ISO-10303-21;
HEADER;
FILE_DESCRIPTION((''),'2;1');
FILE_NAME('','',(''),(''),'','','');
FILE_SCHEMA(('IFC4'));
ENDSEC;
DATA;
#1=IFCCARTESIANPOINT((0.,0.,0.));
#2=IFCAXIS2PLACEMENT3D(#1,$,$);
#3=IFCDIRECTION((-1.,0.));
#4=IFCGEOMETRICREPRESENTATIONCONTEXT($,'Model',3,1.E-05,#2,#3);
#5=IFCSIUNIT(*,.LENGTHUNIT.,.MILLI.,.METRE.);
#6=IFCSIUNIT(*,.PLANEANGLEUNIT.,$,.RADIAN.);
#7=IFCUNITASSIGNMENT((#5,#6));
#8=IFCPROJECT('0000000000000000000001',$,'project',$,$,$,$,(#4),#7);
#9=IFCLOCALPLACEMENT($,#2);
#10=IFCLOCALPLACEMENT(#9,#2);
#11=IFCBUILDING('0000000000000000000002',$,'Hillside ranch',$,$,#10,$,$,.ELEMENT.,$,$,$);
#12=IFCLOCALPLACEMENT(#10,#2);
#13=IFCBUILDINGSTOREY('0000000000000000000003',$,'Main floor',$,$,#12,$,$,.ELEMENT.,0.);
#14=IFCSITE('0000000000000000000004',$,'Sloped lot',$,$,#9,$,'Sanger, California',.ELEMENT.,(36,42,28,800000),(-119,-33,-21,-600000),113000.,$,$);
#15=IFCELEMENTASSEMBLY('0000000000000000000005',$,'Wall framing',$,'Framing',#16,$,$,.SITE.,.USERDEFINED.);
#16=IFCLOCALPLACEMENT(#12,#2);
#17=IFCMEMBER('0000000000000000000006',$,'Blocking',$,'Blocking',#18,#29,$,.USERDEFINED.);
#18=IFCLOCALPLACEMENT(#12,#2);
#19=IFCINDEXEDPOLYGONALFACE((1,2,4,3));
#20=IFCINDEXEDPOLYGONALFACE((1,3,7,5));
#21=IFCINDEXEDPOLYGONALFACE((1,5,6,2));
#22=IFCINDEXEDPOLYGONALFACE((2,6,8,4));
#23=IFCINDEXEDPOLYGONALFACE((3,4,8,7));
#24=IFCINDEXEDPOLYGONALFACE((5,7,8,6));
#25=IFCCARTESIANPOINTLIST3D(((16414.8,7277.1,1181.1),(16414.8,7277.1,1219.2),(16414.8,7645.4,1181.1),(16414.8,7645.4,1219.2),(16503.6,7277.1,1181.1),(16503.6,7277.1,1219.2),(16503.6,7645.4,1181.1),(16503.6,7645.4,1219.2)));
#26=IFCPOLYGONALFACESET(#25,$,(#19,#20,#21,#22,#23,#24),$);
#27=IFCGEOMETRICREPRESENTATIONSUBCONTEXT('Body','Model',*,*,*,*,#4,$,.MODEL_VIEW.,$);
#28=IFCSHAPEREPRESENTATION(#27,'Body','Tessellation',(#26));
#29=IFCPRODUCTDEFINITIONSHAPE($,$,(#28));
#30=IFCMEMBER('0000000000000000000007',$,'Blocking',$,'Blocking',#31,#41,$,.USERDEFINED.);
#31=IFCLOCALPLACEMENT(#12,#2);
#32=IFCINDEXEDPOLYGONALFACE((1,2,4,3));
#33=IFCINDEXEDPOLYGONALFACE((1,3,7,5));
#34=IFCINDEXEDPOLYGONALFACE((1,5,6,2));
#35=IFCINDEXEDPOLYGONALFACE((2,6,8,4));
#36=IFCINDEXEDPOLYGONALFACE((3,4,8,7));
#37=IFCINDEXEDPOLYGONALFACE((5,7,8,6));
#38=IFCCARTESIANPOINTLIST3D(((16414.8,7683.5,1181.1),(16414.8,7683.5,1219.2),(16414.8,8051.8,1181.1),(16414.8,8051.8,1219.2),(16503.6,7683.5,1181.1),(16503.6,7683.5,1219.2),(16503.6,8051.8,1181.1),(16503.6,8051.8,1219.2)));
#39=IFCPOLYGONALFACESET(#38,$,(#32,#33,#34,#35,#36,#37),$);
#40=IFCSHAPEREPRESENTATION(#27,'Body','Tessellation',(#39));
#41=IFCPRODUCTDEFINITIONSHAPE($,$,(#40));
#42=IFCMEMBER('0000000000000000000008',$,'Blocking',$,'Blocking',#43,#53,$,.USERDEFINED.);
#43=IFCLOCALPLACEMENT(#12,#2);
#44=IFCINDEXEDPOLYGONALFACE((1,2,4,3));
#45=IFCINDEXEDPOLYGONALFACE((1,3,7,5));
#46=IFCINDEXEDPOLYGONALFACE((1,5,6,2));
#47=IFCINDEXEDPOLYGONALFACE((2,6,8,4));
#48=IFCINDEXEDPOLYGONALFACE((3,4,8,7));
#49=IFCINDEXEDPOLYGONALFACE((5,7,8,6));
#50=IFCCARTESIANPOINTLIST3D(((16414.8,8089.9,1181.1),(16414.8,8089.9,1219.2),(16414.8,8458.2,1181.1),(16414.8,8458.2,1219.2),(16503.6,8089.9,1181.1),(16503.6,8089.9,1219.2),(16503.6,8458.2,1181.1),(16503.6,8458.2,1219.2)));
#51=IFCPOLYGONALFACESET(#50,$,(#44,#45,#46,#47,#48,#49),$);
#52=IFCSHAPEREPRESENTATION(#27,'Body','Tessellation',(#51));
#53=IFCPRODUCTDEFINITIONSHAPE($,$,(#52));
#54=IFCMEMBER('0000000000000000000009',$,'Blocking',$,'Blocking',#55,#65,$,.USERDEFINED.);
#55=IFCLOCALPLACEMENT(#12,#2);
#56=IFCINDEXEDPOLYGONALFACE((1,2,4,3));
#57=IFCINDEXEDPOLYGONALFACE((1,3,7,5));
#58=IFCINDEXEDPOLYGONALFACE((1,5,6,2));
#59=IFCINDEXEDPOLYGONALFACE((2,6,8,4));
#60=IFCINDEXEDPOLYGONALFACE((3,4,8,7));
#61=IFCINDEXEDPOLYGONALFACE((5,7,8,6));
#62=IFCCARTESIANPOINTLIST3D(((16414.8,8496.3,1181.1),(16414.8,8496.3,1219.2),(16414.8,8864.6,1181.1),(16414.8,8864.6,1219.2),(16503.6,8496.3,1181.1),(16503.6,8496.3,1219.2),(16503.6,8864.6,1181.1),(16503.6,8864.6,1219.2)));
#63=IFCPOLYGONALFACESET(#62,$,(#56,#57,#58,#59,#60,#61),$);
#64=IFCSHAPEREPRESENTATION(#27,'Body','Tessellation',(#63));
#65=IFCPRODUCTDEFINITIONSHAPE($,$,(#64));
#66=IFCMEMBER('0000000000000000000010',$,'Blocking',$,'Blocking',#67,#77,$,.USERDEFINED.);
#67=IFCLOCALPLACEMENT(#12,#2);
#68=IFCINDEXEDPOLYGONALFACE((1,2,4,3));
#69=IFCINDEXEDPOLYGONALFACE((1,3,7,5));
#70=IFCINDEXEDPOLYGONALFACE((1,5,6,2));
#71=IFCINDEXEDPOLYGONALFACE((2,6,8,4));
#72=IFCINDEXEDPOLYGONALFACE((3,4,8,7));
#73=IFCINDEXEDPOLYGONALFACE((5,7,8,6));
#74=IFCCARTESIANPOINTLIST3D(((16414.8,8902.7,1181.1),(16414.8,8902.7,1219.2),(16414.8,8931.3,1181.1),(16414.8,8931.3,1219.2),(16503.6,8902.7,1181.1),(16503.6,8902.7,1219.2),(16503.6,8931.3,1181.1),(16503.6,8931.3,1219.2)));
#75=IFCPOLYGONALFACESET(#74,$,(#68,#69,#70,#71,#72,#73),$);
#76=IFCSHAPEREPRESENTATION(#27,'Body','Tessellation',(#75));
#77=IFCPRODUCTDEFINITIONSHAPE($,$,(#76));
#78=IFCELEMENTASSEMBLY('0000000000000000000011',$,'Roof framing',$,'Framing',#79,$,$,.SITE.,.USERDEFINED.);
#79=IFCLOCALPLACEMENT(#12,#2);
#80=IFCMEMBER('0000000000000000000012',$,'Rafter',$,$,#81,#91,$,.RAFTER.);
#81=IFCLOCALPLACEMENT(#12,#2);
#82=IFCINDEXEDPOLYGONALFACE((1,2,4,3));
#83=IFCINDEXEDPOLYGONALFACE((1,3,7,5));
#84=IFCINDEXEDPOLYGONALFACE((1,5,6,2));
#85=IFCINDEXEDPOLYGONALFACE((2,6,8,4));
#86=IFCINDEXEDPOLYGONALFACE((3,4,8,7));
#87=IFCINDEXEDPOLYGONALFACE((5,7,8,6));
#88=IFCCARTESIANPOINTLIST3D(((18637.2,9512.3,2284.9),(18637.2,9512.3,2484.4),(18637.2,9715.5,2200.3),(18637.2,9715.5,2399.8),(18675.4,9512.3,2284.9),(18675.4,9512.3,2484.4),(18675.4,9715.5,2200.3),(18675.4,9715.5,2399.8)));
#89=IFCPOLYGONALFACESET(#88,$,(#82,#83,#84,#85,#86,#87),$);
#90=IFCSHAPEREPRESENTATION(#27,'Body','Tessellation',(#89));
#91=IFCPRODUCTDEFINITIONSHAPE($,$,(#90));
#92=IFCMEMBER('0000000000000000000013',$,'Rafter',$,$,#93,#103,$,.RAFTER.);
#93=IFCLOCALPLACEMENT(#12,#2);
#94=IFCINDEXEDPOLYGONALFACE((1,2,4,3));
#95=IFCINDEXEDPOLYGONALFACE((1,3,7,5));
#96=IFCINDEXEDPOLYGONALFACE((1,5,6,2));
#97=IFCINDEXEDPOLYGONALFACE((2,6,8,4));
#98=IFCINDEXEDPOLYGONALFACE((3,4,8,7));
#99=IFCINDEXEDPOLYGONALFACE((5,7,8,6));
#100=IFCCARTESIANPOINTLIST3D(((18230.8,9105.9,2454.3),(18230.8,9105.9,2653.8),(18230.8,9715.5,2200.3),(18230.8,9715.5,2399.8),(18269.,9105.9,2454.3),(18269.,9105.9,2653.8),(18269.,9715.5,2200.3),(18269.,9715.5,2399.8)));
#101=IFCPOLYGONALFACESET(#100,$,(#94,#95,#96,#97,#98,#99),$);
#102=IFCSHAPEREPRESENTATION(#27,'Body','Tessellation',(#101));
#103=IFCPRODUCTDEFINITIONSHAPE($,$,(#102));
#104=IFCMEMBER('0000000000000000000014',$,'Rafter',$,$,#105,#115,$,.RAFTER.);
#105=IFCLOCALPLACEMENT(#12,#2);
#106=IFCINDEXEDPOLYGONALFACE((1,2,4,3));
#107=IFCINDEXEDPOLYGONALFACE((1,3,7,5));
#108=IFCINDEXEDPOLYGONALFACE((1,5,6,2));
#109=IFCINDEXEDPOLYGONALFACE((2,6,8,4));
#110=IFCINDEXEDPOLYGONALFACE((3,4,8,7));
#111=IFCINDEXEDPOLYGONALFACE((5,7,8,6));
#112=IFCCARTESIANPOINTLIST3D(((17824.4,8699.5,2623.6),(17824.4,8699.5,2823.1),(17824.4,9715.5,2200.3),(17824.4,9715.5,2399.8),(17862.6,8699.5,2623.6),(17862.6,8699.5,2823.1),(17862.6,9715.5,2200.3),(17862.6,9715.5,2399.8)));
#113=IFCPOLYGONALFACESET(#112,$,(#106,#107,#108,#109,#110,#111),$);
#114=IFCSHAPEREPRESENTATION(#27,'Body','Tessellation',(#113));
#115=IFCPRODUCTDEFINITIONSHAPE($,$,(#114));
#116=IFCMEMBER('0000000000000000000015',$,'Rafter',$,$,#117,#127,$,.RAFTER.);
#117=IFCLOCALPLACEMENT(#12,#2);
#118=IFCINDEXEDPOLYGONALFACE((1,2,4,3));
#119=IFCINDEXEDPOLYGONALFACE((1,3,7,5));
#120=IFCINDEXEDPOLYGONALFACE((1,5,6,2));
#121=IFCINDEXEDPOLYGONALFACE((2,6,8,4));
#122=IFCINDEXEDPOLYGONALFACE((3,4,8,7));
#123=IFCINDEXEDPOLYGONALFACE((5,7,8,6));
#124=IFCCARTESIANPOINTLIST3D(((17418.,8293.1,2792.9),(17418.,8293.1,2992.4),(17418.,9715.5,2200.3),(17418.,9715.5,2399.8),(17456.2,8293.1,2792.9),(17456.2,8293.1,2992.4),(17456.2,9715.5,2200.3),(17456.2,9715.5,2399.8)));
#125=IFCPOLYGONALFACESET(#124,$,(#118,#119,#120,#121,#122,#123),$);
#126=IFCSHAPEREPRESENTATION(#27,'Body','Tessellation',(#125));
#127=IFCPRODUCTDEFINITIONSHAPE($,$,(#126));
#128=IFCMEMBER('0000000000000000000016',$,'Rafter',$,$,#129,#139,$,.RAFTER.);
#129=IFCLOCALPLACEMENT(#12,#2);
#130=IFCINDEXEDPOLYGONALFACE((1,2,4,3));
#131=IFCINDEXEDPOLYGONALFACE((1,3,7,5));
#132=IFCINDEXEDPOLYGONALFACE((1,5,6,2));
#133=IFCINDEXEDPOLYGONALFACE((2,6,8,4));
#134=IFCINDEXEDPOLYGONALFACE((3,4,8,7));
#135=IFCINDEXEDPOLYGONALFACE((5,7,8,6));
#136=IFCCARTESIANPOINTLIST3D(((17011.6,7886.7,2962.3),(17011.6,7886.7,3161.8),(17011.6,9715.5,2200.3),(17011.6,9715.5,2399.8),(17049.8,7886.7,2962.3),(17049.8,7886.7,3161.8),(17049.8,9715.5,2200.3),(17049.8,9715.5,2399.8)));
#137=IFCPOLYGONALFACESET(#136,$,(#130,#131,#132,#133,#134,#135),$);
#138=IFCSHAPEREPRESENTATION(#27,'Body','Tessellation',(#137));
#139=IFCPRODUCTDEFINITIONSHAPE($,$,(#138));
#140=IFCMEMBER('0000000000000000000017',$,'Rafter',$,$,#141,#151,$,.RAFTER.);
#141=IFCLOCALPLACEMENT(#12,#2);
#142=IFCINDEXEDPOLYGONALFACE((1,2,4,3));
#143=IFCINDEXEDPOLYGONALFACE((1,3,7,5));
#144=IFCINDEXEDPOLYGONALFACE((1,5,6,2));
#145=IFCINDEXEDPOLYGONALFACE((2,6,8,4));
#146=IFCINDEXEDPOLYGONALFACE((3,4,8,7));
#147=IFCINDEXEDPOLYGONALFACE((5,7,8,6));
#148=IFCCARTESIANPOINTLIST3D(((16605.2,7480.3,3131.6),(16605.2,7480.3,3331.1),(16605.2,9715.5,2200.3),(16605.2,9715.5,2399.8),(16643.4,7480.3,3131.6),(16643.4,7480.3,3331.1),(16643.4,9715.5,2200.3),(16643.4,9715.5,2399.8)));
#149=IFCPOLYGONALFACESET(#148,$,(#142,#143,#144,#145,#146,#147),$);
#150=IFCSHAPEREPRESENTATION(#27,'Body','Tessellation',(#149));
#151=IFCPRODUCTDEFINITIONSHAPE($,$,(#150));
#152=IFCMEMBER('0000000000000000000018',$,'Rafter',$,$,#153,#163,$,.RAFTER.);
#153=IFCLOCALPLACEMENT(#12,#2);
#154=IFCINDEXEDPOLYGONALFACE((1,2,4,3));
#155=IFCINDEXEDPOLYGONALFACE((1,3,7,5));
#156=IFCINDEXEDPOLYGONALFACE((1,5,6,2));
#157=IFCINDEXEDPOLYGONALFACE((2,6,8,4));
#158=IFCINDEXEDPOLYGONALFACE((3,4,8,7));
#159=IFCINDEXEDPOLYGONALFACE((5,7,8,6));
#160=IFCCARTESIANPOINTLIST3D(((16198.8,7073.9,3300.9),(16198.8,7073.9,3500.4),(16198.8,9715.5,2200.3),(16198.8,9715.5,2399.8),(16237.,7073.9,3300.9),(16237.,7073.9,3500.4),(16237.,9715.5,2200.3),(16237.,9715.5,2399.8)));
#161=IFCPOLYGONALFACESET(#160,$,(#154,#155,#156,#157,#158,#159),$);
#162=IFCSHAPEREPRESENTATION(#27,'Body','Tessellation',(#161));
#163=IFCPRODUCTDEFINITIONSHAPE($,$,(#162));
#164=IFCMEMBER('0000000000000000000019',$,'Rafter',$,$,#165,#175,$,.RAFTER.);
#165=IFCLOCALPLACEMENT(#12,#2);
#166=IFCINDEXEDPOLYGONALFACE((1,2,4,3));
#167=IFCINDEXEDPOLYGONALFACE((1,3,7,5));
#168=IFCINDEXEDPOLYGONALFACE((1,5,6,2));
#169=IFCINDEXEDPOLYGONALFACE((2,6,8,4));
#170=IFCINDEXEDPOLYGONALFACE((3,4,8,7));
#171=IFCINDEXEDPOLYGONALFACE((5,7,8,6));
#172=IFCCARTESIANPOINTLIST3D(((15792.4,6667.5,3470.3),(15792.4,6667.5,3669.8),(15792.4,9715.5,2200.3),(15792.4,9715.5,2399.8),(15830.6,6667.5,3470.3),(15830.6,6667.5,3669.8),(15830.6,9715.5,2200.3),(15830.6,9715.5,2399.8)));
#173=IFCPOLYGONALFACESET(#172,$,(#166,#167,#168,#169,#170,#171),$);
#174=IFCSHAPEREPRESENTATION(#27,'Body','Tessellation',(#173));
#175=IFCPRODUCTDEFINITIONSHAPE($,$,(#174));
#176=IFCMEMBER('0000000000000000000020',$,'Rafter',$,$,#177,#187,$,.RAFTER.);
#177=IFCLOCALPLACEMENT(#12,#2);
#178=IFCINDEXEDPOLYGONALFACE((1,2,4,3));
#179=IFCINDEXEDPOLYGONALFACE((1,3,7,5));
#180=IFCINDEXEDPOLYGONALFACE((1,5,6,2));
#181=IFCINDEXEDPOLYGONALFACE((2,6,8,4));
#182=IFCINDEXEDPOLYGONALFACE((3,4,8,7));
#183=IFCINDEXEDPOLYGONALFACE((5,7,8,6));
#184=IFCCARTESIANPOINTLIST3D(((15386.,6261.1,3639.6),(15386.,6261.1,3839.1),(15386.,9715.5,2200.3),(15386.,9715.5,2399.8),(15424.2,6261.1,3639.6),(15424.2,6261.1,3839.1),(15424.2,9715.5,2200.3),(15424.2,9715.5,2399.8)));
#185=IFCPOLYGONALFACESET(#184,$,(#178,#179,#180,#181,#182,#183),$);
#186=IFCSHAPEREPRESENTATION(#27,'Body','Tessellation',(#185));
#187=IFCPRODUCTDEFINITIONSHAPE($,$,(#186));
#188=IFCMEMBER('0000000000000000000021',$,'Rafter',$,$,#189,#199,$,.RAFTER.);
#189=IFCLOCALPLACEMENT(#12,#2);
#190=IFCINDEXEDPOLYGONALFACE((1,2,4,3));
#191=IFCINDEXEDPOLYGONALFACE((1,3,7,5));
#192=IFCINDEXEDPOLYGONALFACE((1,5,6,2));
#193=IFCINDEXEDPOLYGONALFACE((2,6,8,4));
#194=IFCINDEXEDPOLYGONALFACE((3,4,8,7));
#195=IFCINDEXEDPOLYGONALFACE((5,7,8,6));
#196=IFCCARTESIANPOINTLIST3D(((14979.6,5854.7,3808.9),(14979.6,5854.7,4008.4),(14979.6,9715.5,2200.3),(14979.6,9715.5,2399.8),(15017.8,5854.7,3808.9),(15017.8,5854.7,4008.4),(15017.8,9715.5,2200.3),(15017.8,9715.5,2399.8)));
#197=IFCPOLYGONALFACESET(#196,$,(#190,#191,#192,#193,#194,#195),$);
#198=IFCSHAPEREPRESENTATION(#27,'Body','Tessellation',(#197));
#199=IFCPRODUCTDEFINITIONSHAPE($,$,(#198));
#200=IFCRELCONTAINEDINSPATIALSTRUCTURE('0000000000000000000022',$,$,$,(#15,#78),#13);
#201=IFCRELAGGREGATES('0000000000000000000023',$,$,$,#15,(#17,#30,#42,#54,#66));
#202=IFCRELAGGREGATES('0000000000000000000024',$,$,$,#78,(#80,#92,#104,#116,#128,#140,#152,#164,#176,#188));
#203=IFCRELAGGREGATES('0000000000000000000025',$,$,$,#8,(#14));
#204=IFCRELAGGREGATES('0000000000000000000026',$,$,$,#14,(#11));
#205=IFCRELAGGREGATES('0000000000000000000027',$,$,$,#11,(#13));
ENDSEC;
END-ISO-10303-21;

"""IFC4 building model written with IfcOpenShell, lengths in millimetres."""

from ifc_helpers import new_model, si_unit, direction, frame, origin, origin_with_axes, place, context, subcontext, project, spatial, polyline, outline, extrude, element, aggregate, save


model = new_model("IFC4")

# Units and contexts
model_context = context("Model", 3, precision=1e-05, world=origin(), true_north=direction((-1.0, 0.0)))
body_context = subcontext(model_context, "Body", "Model", "MODEL_VIEW")
ifc_project = project(units=[si_unit("LENGTHUNIT", "METRE", prefix="MILLI"), si_unit("PLANEANGLEUNIT", "RADIAN")], contexts=[model_context])

# Site, building, storey
site_placement = place(None, origin())
site = spatial("IfcSite", under=ifc_project, at=site_placement, Name="Sloped lot", LongName="Sanger, California", CompositionType="ELEMENT", RefLatitude=(36, 42, 28, 800000), RefLongitude=(-119, -33, -21, -600000), RefElevation=113000.0)
building_placement = place(site_placement, origin())
building = spatial("IfcBuilding", under=site, at=building_placement, Name="Hillside ranch", CompositionType="ELEMENT")
storey_placement = place(building_placement, origin())
storey = spatial("IfcBuildingStorey", under=building, at=storey_placement, Name="Main floor", CompositionType="ELEMENT", Elevation=0.0)

# Element assemblies, members
assembly_1_placement = place(storey_placement, origin_with_axes())
assembly_1 = element("IfcElementAssembly", 1, at=assembly_1_placement, inside=storey, Name="Wall framing", ObjectType="Framing", AssemblyPlace="SITE", PredefinedType="USERDEFINED")
member_1_placement = place(storey_placement, origin_with_axes())
member_1 = element("IfcMember", 2, at=member_1_placement, Name="Blocking", ObjectType="Blocking", PredefinedType="USERDEFINED", context=body_context, shape_type="SweptSolid", body=[
    extrude(outline(polyline([(0.0, 0.0), (368.3, 0.0), (368.3, 88.9), (0.0, 88.9), (0.0, 0.0)])), frame((16503.7, 7277.1, 1181.1), z_axis=(0.0, 0.0, 1.0), x_axis=(0.0, 1.0, 0.0)), (0.0, 0.0, 1.0), 38.1),
])
member_2_placement = place(storey_placement, origin_with_axes())
member_2 = element("IfcMember", 3, at=member_2_placement, Name="Blocking", ObjectType="Blocking", PredefinedType="USERDEFINED", context=body_context, shape_type="SweptSolid", body=[
    extrude(outline(polyline([(0.0, 0.0), (368.3, 0.0), (368.3, 88.9), (0.0, 88.9), (0.0, 0.0)])), frame((16503.7, 7683.5, 1181.1), z_axis=(0.0, 0.0, 1.0), x_axis=(0.0, 1.0, 0.0)), (0.0, 0.0, 1.0), 38.1),
])
member_3_placement = place(storey_placement, origin_with_axes())
member_3 = element("IfcMember", 4, at=member_3_placement, Name="Blocking", ObjectType="Blocking", PredefinedType="USERDEFINED", context=body_context, shape_type="SweptSolid", body=[
    extrude(outline(polyline([(0.0, 0.0), (368.3, 0.0), (368.3, 88.9), (0.0, 88.9), (0.0, 0.0)])), frame((16503.7, 8089.9, 1181.1), z_axis=(0.0, 0.0, 1.0), x_axis=(0.0, 1.0, 0.0)), (0.0, 0.0, 1.0), 38.1),
])
member_4_placement = place(storey_placement, origin_with_axes())
member_4 = element("IfcMember", 5, at=member_4_placement, Name="Blocking", ObjectType="Blocking", PredefinedType="USERDEFINED", context=body_context, shape_type="SweptSolid", body=[
    extrude(outline(polyline([(0.0, 0.0), (368.3, 0.0), (368.3, 88.9), (0.0, 88.9), (0.0, 0.0)])), frame((16503.7, 8496.3, 1181.1), z_axis=(0.0, 0.0, 1.0), x_axis=(0.0, 1.0, 0.0)), (0.0, 0.0, 1.0), 38.1),
])
member_5_placement = place(storey_placement, origin_with_axes())
member_5 = element("IfcMember", 6, at=member_5_placement, Name="Blocking", ObjectType="Blocking", PredefinedType="USERDEFINED", context=body_context, shape_type="SweptSolid", body=[
    extrude(outline(polyline([(0.0, 0.0), (28.6, 0.0), (28.6, 88.9), (0.0, 88.9), (0.0, 0.0)])), frame((16503.7, 8902.7, 1181.1), z_axis=(0.0, 0.0, 1.0), x_axis=(0.0, 1.0, 0.0)), (0.0, 0.0, 1.0), 38.1),
])
aggregate(assembly_1, [member_1, member_2, member_3, member_4, member_5])
assembly_2_placement = place(storey_placement, origin_with_axes())
assembly_2 = element("IfcElementAssembly", 7, at=assembly_2_placement, inside=storey, Name="Roof framing", ObjectType="Framing", AssemblyPlace="SITE", PredefinedType="USERDEFINED")
member_6_placement = place(storey_placement, origin_with_axes())
member_6 = element("IfcMember", 8, at=member_6_placement, Name="Rafter", PredefinedType="RAFTER", context=body_context, shape_type="SweptSolid", body=[
    extrude(outline(polyline([(0.0, 0.0), (38.1, 0.0), (38.1, 199.5), (0.0, 199.5), (0.0, 0.0)])), frame((18637.2, 9715.5, 2200.3), z_axis=(0.0, -1.0, 0.0), x_axis=(1.0, 0.0, 0.0)), (0.0, 0.384615, 0.923077), 220.1),
])
member_7_placement = place(storey_placement, origin_with_axes())
member_7 = element("IfcMember", 9, at=member_7_placement, Name="Rafter", PredefinedType="RAFTER", context=body_context, shape_type="SweptSolid", body=[
    extrude(outline(polyline([(0.0, 0.0), (38.1, 0.0), (38.1, 199.5), (0.0, 199.5), (0.0, 0.0)])), frame((18230.8, 9715.5, 2200.3), z_axis=(0.0, -1.0, 0.0), x_axis=(1.0, 0.0, 0.0)), (0.0, 0.384615, 0.923077), 660.4),
])
member_8_placement = place(storey_placement, origin_with_axes())
member_8 = element("IfcMember", 10, at=member_8_placement, Name="Rafter", PredefinedType="RAFTER", context=body_context, shape_type="SweptSolid", body=[
    extrude(outline(polyline([(0.0, 0.0), (38.1, 0.0), (38.1, 199.5), (0.0, 199.5), (0.0, 0.0)])), frame((17824.5, 9715.5, 2200.3), z_axis=(0.0, -1.0, 0.0), x_axis=(1.0, 0.0, 0.0)), (0.0, 0.384615, 0.923077), 1100.7),
])
member_9_placement = place(storey_placement, origin_with_axes())
member_9 = element("IfcMember", 11, at=member_9_placement, Name="Rafter", PredefinedType="RAFTER", context=body_context, shape_type="SweptSolid", body=[
    extrude(outline(polyline([(0.0, 0.0), (38.1, 0.0), (38.1, 199.5), (0.0, 199.5), (0.0, 0.0)])), frame((17418.0, 9715.5, 2200.3), z_axis=(0.0, -1.0, 0.0), x_axis=(1.0, 0.0, 0.0)), (0.0, 0.384615, 0.923077), 1540.9),
])
member_10_placement = place(storey_placement, origin_with_axes())
member_10 = element("IfcMember", 12, at=member_10_placement, Name="Rafter", PredefinedType="RAFTER", context=body_context, shape_type="SweptSolid", body=[
    extrude(outline(polyline([(0.0, 0.0), (38.1, 0.0), (38.1, 199.5), (0.0, 199.5), (0.0, 0.0)])), frame((17011.7, 9715.5, 2200.3), z_axis=(0.0, -1.0, 0.0), x_axis=(1.0, 0.0, 0.0)), (0.0, 0.384615, 0.923077), 1981.2),
])
member_11_placement = place(storey_placement, origin_with_axes())
member_11 = element("IfcMember", 13, at=member_11_placement, Name="Rafter", PredefinedType="RAFTER", context=body_context, shape_type="SweptSolid", body=[
    extrude(outline(polyline([(0.0, 0.0), (38.1, 0.0), (38.1, 199.5), (0.0, 199.5), (0.0, 0.0)])), frame((16605.2, 9715.5, 2200.3), z_axis=(0.0, -1.0, 0.0), x_axis=(1.0, 0.0, 0.0)), (0.0, 0.384615, 0.923077), 2421.5),
])
member_12_placement = place(storey_placement, origin_with_axes())
member_12 = element("IfcMember", 14, at=member_12_placement, Name="Rafter", PredefinedType="RAFTER", context=body_context, shape_type="SweptSolid", body=[
    extrude(outline(polyline([(0.0, 0.0), (38.1, 0.0), (38.1, 199.5), (0.0, 199.5), (0.0, 0.0)])), frame((16198.9, 9715.5, 2200.3), z_axis=(0.0, -1.0, 0.0), x_axis=(1.0, 0.0, 0.0)), (0.0, 0.384615, 0.923077), 2861.7),
])
member_13_placement = place(storey_placement, origin_with_axes())
member_13 = element("IfcMember", 15, at=member_13_placement, Name="Rafter", PredefinedType="RAFTER", context=body_context, shape_type="SweptSolid", body=[
    extrude(outline(polyline([(0.0, 0.0), (38.1, 0.0), (38.1, 199.5), (0.0, 199.5), (0.0, 0.0)])), frame((15792.5, 9715.5, 2200.3), z_axis=(0.0, -1.0, 0.0), x_axis=(1.0, 0.0, 0.0)), (0.0, 0.384615, 0.923077), 3302.0),
])
member_14_placement = place(storey_placement, origin_with_axes())
member_14 = element("IfcMember", 16, at=member_14_placement, Name="Rafter", PredefinedType="RAFTER", context=body_context, shape_type="SweptSolid", body=[
    extrude(outline(polyline([(0.0, 0.0), (38.1, 0.0), (38.1, 199.5), (0.0, 199.5), (0.0, 0.0)])), frame((15386.0, 9715.5, 2200.3), z_axis=(0.0, -1.0, 0.0), x_axis=(1.0, 0.0, 0.0)), (0.0, 0.384615, 0.923077), 3742.3),
])
member_15_placement = place(storey_placement, origin_with_axes())
member_15 = element("IfcMember", 17, at=member_15_placement, Name="Rafter", PredefinedType="RAFTER", context=body_context, shape_type="SweptSolid", body=[
    extrude(outline(polyline([(0.0, 0.0), (38.1, 0.0), (38.1, 199.5), (0.0, 199.5), (0.0, 0.0)])), frame((14979.6, 9715.5, 2200.3), z_axis=(0.0, -1.0, 0.0), x_axis=(1.0, 0.0, 0.0)), (0.0, 0.384615, 0.923077), 4182.5),
])
aggregate(assembly_2, [member_6, member_7, member_8, member_9, member_10, member_11, member_12, member_13, member_14, member_15])

save(model, "model.ifc")
